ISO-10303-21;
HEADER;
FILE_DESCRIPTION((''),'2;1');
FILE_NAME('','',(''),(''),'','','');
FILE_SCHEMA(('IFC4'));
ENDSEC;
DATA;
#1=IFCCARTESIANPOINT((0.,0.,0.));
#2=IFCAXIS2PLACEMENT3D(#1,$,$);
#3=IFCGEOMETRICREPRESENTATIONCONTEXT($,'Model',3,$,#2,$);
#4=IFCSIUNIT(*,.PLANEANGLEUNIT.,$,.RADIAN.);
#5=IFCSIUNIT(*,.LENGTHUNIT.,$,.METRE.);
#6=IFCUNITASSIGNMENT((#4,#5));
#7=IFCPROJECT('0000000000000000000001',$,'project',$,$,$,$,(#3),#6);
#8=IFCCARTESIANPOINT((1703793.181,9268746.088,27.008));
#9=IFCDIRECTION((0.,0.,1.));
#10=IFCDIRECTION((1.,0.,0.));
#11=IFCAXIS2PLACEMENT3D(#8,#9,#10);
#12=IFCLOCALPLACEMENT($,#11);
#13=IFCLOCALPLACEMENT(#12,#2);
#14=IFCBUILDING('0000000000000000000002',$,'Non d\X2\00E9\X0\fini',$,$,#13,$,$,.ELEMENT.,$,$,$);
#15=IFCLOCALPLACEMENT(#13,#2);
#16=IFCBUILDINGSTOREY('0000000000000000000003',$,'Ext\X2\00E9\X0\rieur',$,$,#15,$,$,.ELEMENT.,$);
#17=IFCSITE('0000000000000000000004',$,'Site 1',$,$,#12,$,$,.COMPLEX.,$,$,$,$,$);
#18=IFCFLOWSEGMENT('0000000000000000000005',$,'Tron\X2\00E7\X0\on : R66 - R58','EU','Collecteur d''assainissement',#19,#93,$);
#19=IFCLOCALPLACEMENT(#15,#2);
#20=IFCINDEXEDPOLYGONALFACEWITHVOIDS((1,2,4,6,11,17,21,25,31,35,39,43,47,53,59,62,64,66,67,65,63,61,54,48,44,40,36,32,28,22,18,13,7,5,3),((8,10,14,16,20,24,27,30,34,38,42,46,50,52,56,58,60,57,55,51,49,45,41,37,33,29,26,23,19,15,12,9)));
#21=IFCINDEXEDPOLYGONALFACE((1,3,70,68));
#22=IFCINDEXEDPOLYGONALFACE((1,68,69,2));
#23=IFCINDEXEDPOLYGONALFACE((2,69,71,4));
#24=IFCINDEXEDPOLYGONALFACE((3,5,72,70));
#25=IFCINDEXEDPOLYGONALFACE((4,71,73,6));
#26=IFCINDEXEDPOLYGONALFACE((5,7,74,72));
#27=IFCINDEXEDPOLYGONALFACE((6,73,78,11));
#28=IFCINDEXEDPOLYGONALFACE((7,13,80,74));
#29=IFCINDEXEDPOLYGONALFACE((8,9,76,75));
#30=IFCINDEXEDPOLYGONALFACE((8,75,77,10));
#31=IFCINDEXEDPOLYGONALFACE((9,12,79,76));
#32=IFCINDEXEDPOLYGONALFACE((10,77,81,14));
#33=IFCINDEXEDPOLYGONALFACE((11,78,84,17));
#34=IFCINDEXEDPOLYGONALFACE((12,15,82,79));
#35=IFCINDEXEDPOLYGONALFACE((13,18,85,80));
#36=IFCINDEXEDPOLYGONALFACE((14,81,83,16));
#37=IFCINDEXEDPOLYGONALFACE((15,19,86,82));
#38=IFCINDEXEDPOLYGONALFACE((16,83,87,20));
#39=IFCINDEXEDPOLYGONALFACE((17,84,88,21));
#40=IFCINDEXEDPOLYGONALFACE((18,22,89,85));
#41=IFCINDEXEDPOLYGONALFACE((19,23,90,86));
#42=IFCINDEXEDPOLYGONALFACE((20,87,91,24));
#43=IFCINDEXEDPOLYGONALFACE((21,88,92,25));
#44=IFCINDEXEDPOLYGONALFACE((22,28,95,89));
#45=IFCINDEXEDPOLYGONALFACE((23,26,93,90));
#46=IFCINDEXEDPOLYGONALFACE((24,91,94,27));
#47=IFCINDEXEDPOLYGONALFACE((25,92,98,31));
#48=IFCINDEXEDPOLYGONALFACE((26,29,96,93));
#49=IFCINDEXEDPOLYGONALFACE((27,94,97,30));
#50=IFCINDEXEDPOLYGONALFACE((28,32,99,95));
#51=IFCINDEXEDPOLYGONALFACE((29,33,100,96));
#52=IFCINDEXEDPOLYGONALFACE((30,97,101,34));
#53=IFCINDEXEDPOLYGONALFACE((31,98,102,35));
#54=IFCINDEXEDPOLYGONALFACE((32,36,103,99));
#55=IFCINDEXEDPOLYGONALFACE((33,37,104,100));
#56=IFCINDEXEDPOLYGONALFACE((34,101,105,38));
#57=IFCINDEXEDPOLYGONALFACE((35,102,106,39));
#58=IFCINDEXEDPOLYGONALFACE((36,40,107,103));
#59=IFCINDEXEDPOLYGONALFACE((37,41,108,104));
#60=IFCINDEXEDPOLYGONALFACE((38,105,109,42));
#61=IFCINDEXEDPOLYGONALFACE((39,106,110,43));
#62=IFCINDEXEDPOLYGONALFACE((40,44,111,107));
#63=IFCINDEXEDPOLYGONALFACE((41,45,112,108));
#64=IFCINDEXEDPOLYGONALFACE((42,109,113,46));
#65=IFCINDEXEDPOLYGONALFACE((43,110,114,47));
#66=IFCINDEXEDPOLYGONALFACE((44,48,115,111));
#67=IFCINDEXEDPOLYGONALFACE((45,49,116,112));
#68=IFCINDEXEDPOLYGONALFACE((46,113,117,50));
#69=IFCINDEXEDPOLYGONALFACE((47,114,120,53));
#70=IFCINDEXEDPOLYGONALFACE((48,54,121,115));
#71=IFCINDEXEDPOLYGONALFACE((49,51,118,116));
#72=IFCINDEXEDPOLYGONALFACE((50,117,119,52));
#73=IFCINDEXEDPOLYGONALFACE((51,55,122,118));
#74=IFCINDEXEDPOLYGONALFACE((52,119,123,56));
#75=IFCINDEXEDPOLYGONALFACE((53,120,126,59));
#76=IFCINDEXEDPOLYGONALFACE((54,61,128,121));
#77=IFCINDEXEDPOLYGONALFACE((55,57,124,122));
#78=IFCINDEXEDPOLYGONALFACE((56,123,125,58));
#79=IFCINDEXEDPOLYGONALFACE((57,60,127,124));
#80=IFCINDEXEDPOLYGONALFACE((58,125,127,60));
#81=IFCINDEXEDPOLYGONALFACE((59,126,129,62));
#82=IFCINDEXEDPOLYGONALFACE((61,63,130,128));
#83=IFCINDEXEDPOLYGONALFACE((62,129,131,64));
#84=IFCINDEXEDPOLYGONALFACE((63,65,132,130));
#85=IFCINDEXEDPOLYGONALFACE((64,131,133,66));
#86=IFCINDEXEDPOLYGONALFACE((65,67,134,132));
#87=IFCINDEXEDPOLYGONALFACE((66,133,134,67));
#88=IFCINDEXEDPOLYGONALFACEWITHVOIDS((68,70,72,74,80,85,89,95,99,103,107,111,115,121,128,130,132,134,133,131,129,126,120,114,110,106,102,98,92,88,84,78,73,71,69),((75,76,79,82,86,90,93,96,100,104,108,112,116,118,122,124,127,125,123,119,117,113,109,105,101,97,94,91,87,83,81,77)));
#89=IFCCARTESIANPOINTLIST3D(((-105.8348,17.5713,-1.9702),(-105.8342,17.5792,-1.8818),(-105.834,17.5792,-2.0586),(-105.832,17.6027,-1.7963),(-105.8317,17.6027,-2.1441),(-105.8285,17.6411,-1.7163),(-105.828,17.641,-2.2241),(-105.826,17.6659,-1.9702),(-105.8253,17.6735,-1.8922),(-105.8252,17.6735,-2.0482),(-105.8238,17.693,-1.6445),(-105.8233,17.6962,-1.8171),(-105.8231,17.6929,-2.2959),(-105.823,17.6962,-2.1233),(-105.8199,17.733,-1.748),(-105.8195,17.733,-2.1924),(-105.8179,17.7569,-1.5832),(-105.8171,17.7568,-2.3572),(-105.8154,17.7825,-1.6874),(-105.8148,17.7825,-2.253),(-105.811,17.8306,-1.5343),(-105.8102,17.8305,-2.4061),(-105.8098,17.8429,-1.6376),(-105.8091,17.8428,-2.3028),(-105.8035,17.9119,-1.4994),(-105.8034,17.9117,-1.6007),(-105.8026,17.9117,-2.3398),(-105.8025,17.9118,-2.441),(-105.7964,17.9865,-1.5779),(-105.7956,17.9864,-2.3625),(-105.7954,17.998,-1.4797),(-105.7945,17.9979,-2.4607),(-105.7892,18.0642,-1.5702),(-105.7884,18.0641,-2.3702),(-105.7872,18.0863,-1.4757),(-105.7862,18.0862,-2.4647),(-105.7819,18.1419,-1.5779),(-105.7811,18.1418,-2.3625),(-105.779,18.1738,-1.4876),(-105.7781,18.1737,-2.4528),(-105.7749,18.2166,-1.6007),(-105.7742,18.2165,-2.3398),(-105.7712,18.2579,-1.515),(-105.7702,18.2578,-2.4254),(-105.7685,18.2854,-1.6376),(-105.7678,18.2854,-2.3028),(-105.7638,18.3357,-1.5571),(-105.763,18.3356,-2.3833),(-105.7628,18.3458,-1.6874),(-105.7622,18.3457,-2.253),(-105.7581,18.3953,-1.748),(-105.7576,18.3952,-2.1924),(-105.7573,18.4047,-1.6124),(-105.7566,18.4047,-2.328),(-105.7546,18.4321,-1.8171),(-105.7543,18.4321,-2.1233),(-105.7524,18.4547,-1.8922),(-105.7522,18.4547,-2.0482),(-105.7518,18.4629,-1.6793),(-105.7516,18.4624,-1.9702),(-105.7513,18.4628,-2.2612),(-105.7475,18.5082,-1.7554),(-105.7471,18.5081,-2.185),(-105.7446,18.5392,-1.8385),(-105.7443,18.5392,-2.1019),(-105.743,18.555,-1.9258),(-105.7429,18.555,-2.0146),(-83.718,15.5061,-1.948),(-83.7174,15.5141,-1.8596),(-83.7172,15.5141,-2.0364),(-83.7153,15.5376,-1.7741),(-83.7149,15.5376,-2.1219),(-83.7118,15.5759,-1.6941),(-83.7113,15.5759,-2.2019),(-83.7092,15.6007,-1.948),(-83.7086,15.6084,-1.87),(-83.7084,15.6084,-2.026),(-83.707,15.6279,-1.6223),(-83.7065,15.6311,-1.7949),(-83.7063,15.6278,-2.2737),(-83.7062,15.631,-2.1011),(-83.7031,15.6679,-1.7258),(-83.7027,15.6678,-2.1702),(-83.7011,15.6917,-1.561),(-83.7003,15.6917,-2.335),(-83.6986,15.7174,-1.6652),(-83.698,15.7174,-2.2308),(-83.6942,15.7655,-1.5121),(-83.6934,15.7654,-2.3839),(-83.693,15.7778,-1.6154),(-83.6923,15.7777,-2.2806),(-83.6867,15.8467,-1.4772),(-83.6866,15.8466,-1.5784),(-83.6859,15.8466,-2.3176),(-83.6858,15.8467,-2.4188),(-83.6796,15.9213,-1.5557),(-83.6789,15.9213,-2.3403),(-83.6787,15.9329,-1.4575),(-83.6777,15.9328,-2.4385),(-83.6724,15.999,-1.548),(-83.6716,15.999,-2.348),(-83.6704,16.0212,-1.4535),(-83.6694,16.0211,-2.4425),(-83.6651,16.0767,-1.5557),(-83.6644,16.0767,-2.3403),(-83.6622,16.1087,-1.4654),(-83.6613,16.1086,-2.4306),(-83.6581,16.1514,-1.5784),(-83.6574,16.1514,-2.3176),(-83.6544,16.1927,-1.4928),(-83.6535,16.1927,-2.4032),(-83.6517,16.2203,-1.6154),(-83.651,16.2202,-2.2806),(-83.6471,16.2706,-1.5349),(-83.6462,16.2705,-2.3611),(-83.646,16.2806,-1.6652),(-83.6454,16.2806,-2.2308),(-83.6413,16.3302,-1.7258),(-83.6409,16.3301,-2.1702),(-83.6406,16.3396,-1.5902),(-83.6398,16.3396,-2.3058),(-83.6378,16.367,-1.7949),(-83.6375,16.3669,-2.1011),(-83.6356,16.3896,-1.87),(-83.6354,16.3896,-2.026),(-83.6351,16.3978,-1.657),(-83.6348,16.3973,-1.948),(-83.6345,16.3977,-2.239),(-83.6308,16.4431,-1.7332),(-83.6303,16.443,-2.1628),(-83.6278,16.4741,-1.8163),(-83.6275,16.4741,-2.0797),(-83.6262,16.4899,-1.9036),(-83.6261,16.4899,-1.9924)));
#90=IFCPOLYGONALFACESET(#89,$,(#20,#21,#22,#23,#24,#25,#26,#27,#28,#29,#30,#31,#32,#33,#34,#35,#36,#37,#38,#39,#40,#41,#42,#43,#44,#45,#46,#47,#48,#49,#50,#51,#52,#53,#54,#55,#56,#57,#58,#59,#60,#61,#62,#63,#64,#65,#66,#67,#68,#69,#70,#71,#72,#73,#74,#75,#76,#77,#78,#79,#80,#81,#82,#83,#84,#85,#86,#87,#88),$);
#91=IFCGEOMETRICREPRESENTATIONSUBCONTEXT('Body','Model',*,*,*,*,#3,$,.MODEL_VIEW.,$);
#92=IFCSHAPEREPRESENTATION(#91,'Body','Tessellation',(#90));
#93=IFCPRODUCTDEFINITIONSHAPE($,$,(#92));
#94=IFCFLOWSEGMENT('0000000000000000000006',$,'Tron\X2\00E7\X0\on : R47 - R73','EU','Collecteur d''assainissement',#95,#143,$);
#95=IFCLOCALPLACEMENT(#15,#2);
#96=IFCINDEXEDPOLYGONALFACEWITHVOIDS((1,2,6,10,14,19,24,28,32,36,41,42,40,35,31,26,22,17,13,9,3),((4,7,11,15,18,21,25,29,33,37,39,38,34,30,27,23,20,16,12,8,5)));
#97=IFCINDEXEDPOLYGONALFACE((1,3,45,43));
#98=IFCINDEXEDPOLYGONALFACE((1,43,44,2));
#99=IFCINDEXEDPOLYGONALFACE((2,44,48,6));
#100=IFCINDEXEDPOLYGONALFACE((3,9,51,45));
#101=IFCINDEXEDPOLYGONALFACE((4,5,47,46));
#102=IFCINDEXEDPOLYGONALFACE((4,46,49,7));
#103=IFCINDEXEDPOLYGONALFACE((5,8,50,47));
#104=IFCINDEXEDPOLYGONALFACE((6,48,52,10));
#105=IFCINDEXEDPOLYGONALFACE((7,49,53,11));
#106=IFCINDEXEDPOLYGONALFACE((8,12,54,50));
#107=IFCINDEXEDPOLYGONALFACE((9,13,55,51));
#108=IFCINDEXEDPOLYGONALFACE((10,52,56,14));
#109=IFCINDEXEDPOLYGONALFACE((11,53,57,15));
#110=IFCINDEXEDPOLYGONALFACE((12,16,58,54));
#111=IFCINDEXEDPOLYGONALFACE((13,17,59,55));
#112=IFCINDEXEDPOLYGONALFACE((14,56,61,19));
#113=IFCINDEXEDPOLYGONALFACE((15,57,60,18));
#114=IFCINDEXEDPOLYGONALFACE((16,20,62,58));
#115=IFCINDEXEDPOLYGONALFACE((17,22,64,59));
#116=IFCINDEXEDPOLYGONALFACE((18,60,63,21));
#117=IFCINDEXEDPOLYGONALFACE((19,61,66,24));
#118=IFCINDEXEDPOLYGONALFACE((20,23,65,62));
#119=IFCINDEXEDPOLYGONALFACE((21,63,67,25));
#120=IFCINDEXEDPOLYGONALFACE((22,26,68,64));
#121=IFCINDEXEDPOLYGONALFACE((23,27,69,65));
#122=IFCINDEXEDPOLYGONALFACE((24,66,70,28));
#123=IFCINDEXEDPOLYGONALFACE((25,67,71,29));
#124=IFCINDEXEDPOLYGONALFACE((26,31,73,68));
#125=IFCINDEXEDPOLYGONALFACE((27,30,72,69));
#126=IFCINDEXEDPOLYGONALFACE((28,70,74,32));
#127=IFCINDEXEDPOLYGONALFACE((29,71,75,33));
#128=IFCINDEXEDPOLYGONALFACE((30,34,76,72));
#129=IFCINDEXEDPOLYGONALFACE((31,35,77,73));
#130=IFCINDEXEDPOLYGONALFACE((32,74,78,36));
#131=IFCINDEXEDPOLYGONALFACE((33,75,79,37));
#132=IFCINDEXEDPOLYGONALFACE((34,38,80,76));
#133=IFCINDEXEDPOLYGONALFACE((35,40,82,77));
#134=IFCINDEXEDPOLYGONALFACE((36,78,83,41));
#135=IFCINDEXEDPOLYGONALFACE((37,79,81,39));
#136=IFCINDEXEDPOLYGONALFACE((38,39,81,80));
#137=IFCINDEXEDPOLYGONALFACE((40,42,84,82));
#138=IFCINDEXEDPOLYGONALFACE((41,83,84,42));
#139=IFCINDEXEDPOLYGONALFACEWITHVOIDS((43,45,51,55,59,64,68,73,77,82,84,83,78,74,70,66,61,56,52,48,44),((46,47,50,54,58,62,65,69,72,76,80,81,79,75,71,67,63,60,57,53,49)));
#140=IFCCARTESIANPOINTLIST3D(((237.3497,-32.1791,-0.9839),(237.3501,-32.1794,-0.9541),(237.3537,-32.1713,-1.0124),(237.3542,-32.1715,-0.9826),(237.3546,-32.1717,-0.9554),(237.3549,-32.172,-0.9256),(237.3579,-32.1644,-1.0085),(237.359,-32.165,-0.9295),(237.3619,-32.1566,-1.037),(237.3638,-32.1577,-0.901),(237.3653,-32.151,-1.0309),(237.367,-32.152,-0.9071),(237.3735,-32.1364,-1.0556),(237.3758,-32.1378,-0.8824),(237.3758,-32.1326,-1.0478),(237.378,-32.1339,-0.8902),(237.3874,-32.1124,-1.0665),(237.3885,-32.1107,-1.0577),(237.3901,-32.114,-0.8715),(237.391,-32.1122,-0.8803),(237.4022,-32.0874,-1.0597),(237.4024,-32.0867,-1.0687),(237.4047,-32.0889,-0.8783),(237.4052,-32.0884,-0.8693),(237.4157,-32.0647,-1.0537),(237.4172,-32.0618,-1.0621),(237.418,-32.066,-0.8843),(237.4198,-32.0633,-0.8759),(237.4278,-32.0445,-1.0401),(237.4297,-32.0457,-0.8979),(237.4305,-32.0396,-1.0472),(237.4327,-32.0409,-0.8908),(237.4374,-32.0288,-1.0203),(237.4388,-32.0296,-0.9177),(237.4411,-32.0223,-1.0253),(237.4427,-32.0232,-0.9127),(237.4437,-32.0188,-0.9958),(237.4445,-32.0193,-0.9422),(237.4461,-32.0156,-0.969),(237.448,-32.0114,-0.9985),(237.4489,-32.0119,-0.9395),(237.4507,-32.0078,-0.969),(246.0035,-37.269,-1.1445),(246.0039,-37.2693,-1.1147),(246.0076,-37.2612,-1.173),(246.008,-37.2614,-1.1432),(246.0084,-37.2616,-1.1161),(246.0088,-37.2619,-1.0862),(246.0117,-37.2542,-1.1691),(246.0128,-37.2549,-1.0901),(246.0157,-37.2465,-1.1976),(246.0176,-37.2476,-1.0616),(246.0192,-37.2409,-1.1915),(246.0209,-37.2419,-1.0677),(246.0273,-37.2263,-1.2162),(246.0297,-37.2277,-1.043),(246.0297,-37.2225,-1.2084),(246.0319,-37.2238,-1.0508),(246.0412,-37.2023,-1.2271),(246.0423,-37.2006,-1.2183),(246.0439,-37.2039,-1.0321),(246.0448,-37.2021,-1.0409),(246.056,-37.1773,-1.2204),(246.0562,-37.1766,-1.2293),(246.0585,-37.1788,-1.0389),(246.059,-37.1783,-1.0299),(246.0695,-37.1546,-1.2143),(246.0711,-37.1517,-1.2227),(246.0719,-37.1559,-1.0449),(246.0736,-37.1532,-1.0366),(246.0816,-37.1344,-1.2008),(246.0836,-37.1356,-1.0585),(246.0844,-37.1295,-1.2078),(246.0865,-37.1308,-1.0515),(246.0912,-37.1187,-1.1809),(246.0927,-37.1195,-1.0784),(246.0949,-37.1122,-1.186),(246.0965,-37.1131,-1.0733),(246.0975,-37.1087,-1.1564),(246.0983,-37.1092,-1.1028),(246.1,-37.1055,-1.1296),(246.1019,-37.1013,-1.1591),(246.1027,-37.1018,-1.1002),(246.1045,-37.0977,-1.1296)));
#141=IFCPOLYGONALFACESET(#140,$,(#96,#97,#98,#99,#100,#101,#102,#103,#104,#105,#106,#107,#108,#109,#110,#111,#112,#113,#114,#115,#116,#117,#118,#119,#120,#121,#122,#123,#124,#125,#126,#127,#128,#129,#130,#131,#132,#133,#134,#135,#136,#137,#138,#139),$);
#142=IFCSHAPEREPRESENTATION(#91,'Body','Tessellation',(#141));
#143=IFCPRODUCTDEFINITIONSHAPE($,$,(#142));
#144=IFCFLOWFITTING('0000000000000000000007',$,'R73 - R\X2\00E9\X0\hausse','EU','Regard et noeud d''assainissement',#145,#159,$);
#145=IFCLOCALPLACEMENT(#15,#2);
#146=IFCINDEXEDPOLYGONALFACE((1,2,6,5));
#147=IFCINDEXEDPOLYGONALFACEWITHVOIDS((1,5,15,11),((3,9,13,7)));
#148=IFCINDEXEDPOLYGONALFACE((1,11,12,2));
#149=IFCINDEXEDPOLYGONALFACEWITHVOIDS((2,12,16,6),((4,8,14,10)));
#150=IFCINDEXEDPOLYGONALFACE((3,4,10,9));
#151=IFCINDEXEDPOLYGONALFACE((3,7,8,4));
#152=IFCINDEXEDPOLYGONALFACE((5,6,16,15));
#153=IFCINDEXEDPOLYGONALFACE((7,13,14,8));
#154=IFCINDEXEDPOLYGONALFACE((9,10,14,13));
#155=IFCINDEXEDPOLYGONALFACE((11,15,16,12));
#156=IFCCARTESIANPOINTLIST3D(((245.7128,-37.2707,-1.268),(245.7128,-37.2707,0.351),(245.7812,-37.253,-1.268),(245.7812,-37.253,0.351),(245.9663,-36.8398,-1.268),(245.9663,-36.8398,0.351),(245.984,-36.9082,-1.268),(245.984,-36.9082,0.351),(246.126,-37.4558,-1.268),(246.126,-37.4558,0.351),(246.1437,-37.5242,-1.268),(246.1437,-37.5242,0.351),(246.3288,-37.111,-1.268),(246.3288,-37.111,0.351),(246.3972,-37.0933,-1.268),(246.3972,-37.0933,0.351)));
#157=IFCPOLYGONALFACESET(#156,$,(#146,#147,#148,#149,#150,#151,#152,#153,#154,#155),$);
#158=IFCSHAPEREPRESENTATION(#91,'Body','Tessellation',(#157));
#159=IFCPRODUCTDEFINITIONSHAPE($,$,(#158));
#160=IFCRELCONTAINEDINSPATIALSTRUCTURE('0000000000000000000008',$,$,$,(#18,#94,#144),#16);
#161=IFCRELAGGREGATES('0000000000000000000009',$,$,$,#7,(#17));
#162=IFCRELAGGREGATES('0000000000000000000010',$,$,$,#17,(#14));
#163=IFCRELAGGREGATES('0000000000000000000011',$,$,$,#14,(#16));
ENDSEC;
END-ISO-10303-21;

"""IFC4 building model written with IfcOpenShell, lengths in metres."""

from ifc_helpers import new_model, si_unit, frame, origin, origin_2d, place, context, subcontext, project, spatial, hollow_rectangle, hollow_circle, extrude, element, save


model = new_model("IFC4")

# Units and contexts
model_context = context("Model", 3, world=origin())
body_context = subcontext(model_context, "Body", "Model", "MODEL_VIEW")
ifc_project = project(units=[si_unit("PLANEANGLEUNIT", "RADIAN"), si_unit("LENGTHUNIT", "METRE")], contexts=[model_context])

# Site, building, storey
site_placement = place(None, frame((1703793.181, 9268746.088, 27.008), z_axis=(0.0, 0.0, 1.0), x_axis=(1.0, 0.0, 0.0)))
site = spatial("IfcSite", under=ifc_project, at=site_placement, Name="Site 1", CompositionType="COMPLEX")
building_placement = place(site_placement, origin())
building = spatial("IfcBuilding", under=site, at=building_placement, Name="Non défini", CompositionType="ELEMENT")
storey_placement = place(building_placement, origin())
storey = spatial("IfcBuildingStorey", under=building, at=storey_placement, Name="Extérieur", CompositionType="ELEMENT")

# Flow segments
flow_segment_1_placement = place(storey_placement, origin())
element("IfcFlowSegment", 1, at=flow_segment_1_placement, inside=storey, Name="Tronçon : R66 - R58", Description="EU", ObjectType="Collecteur d'assainissement", context=body_context, shape_type="SweptSolid", body=[
    extrude(hollow_circle(Radius=0.495, WallThickness=0.095, at=origin_2d()), frame((-83.672, 15.999, -1.948), z_axis=(-0.996, 0.093, -0.001), x_axis=(-0.093, -0.996, 0.0)), (0.0, 0.0, 1.0), 22.213),
])
flow_segment_2_placement = place(storey_placement, origin())
element("IfcFlowSegment", 2, at=flow_segment_2_placement, inside=storey, Name="Tronçon : R47 - R73", Description="EU", ObjectType="Collecteur d'assainissement", context=body_context, shape_type="SweptSolid", body=[
    extrude(hollow_circle(Radius=0.1, WallThickness=0.009, at=origin_2d()), frame((237.4, -32.094, -0.969), z_axis=(0.862, -0.507, -0.016), x_axis=(0.507, 0.862, 0.0)), (0.0, 0.0, 1.0), 10.041),
])

# Flow fitting
for number, where, name in (
    (3, (0.0, 0.0, 0.0), "R73 - Réhausse"),
):
    element("IfcFlowFitting", number, at=place(storey_placement, frame(where)), inside=storey, Name=name, Description="EU", ObjectType="Regard et noeud d'assainissement", context=body_context, shape_type="SweptSolid", body=[
        extrude(hollow_rectangle(XDim=0.5, YDim=0.5, WallThickness=0.05, at=origin_2d()), frame((246.055, -37.182, -1.268), z_axis=(0.0, 0.0, 1.0), x_axis=(0.862, -0.507, 0.0)), (0.0, 0.0, 1.0), 1.619),
    ])

save(model, "model.ifc")
